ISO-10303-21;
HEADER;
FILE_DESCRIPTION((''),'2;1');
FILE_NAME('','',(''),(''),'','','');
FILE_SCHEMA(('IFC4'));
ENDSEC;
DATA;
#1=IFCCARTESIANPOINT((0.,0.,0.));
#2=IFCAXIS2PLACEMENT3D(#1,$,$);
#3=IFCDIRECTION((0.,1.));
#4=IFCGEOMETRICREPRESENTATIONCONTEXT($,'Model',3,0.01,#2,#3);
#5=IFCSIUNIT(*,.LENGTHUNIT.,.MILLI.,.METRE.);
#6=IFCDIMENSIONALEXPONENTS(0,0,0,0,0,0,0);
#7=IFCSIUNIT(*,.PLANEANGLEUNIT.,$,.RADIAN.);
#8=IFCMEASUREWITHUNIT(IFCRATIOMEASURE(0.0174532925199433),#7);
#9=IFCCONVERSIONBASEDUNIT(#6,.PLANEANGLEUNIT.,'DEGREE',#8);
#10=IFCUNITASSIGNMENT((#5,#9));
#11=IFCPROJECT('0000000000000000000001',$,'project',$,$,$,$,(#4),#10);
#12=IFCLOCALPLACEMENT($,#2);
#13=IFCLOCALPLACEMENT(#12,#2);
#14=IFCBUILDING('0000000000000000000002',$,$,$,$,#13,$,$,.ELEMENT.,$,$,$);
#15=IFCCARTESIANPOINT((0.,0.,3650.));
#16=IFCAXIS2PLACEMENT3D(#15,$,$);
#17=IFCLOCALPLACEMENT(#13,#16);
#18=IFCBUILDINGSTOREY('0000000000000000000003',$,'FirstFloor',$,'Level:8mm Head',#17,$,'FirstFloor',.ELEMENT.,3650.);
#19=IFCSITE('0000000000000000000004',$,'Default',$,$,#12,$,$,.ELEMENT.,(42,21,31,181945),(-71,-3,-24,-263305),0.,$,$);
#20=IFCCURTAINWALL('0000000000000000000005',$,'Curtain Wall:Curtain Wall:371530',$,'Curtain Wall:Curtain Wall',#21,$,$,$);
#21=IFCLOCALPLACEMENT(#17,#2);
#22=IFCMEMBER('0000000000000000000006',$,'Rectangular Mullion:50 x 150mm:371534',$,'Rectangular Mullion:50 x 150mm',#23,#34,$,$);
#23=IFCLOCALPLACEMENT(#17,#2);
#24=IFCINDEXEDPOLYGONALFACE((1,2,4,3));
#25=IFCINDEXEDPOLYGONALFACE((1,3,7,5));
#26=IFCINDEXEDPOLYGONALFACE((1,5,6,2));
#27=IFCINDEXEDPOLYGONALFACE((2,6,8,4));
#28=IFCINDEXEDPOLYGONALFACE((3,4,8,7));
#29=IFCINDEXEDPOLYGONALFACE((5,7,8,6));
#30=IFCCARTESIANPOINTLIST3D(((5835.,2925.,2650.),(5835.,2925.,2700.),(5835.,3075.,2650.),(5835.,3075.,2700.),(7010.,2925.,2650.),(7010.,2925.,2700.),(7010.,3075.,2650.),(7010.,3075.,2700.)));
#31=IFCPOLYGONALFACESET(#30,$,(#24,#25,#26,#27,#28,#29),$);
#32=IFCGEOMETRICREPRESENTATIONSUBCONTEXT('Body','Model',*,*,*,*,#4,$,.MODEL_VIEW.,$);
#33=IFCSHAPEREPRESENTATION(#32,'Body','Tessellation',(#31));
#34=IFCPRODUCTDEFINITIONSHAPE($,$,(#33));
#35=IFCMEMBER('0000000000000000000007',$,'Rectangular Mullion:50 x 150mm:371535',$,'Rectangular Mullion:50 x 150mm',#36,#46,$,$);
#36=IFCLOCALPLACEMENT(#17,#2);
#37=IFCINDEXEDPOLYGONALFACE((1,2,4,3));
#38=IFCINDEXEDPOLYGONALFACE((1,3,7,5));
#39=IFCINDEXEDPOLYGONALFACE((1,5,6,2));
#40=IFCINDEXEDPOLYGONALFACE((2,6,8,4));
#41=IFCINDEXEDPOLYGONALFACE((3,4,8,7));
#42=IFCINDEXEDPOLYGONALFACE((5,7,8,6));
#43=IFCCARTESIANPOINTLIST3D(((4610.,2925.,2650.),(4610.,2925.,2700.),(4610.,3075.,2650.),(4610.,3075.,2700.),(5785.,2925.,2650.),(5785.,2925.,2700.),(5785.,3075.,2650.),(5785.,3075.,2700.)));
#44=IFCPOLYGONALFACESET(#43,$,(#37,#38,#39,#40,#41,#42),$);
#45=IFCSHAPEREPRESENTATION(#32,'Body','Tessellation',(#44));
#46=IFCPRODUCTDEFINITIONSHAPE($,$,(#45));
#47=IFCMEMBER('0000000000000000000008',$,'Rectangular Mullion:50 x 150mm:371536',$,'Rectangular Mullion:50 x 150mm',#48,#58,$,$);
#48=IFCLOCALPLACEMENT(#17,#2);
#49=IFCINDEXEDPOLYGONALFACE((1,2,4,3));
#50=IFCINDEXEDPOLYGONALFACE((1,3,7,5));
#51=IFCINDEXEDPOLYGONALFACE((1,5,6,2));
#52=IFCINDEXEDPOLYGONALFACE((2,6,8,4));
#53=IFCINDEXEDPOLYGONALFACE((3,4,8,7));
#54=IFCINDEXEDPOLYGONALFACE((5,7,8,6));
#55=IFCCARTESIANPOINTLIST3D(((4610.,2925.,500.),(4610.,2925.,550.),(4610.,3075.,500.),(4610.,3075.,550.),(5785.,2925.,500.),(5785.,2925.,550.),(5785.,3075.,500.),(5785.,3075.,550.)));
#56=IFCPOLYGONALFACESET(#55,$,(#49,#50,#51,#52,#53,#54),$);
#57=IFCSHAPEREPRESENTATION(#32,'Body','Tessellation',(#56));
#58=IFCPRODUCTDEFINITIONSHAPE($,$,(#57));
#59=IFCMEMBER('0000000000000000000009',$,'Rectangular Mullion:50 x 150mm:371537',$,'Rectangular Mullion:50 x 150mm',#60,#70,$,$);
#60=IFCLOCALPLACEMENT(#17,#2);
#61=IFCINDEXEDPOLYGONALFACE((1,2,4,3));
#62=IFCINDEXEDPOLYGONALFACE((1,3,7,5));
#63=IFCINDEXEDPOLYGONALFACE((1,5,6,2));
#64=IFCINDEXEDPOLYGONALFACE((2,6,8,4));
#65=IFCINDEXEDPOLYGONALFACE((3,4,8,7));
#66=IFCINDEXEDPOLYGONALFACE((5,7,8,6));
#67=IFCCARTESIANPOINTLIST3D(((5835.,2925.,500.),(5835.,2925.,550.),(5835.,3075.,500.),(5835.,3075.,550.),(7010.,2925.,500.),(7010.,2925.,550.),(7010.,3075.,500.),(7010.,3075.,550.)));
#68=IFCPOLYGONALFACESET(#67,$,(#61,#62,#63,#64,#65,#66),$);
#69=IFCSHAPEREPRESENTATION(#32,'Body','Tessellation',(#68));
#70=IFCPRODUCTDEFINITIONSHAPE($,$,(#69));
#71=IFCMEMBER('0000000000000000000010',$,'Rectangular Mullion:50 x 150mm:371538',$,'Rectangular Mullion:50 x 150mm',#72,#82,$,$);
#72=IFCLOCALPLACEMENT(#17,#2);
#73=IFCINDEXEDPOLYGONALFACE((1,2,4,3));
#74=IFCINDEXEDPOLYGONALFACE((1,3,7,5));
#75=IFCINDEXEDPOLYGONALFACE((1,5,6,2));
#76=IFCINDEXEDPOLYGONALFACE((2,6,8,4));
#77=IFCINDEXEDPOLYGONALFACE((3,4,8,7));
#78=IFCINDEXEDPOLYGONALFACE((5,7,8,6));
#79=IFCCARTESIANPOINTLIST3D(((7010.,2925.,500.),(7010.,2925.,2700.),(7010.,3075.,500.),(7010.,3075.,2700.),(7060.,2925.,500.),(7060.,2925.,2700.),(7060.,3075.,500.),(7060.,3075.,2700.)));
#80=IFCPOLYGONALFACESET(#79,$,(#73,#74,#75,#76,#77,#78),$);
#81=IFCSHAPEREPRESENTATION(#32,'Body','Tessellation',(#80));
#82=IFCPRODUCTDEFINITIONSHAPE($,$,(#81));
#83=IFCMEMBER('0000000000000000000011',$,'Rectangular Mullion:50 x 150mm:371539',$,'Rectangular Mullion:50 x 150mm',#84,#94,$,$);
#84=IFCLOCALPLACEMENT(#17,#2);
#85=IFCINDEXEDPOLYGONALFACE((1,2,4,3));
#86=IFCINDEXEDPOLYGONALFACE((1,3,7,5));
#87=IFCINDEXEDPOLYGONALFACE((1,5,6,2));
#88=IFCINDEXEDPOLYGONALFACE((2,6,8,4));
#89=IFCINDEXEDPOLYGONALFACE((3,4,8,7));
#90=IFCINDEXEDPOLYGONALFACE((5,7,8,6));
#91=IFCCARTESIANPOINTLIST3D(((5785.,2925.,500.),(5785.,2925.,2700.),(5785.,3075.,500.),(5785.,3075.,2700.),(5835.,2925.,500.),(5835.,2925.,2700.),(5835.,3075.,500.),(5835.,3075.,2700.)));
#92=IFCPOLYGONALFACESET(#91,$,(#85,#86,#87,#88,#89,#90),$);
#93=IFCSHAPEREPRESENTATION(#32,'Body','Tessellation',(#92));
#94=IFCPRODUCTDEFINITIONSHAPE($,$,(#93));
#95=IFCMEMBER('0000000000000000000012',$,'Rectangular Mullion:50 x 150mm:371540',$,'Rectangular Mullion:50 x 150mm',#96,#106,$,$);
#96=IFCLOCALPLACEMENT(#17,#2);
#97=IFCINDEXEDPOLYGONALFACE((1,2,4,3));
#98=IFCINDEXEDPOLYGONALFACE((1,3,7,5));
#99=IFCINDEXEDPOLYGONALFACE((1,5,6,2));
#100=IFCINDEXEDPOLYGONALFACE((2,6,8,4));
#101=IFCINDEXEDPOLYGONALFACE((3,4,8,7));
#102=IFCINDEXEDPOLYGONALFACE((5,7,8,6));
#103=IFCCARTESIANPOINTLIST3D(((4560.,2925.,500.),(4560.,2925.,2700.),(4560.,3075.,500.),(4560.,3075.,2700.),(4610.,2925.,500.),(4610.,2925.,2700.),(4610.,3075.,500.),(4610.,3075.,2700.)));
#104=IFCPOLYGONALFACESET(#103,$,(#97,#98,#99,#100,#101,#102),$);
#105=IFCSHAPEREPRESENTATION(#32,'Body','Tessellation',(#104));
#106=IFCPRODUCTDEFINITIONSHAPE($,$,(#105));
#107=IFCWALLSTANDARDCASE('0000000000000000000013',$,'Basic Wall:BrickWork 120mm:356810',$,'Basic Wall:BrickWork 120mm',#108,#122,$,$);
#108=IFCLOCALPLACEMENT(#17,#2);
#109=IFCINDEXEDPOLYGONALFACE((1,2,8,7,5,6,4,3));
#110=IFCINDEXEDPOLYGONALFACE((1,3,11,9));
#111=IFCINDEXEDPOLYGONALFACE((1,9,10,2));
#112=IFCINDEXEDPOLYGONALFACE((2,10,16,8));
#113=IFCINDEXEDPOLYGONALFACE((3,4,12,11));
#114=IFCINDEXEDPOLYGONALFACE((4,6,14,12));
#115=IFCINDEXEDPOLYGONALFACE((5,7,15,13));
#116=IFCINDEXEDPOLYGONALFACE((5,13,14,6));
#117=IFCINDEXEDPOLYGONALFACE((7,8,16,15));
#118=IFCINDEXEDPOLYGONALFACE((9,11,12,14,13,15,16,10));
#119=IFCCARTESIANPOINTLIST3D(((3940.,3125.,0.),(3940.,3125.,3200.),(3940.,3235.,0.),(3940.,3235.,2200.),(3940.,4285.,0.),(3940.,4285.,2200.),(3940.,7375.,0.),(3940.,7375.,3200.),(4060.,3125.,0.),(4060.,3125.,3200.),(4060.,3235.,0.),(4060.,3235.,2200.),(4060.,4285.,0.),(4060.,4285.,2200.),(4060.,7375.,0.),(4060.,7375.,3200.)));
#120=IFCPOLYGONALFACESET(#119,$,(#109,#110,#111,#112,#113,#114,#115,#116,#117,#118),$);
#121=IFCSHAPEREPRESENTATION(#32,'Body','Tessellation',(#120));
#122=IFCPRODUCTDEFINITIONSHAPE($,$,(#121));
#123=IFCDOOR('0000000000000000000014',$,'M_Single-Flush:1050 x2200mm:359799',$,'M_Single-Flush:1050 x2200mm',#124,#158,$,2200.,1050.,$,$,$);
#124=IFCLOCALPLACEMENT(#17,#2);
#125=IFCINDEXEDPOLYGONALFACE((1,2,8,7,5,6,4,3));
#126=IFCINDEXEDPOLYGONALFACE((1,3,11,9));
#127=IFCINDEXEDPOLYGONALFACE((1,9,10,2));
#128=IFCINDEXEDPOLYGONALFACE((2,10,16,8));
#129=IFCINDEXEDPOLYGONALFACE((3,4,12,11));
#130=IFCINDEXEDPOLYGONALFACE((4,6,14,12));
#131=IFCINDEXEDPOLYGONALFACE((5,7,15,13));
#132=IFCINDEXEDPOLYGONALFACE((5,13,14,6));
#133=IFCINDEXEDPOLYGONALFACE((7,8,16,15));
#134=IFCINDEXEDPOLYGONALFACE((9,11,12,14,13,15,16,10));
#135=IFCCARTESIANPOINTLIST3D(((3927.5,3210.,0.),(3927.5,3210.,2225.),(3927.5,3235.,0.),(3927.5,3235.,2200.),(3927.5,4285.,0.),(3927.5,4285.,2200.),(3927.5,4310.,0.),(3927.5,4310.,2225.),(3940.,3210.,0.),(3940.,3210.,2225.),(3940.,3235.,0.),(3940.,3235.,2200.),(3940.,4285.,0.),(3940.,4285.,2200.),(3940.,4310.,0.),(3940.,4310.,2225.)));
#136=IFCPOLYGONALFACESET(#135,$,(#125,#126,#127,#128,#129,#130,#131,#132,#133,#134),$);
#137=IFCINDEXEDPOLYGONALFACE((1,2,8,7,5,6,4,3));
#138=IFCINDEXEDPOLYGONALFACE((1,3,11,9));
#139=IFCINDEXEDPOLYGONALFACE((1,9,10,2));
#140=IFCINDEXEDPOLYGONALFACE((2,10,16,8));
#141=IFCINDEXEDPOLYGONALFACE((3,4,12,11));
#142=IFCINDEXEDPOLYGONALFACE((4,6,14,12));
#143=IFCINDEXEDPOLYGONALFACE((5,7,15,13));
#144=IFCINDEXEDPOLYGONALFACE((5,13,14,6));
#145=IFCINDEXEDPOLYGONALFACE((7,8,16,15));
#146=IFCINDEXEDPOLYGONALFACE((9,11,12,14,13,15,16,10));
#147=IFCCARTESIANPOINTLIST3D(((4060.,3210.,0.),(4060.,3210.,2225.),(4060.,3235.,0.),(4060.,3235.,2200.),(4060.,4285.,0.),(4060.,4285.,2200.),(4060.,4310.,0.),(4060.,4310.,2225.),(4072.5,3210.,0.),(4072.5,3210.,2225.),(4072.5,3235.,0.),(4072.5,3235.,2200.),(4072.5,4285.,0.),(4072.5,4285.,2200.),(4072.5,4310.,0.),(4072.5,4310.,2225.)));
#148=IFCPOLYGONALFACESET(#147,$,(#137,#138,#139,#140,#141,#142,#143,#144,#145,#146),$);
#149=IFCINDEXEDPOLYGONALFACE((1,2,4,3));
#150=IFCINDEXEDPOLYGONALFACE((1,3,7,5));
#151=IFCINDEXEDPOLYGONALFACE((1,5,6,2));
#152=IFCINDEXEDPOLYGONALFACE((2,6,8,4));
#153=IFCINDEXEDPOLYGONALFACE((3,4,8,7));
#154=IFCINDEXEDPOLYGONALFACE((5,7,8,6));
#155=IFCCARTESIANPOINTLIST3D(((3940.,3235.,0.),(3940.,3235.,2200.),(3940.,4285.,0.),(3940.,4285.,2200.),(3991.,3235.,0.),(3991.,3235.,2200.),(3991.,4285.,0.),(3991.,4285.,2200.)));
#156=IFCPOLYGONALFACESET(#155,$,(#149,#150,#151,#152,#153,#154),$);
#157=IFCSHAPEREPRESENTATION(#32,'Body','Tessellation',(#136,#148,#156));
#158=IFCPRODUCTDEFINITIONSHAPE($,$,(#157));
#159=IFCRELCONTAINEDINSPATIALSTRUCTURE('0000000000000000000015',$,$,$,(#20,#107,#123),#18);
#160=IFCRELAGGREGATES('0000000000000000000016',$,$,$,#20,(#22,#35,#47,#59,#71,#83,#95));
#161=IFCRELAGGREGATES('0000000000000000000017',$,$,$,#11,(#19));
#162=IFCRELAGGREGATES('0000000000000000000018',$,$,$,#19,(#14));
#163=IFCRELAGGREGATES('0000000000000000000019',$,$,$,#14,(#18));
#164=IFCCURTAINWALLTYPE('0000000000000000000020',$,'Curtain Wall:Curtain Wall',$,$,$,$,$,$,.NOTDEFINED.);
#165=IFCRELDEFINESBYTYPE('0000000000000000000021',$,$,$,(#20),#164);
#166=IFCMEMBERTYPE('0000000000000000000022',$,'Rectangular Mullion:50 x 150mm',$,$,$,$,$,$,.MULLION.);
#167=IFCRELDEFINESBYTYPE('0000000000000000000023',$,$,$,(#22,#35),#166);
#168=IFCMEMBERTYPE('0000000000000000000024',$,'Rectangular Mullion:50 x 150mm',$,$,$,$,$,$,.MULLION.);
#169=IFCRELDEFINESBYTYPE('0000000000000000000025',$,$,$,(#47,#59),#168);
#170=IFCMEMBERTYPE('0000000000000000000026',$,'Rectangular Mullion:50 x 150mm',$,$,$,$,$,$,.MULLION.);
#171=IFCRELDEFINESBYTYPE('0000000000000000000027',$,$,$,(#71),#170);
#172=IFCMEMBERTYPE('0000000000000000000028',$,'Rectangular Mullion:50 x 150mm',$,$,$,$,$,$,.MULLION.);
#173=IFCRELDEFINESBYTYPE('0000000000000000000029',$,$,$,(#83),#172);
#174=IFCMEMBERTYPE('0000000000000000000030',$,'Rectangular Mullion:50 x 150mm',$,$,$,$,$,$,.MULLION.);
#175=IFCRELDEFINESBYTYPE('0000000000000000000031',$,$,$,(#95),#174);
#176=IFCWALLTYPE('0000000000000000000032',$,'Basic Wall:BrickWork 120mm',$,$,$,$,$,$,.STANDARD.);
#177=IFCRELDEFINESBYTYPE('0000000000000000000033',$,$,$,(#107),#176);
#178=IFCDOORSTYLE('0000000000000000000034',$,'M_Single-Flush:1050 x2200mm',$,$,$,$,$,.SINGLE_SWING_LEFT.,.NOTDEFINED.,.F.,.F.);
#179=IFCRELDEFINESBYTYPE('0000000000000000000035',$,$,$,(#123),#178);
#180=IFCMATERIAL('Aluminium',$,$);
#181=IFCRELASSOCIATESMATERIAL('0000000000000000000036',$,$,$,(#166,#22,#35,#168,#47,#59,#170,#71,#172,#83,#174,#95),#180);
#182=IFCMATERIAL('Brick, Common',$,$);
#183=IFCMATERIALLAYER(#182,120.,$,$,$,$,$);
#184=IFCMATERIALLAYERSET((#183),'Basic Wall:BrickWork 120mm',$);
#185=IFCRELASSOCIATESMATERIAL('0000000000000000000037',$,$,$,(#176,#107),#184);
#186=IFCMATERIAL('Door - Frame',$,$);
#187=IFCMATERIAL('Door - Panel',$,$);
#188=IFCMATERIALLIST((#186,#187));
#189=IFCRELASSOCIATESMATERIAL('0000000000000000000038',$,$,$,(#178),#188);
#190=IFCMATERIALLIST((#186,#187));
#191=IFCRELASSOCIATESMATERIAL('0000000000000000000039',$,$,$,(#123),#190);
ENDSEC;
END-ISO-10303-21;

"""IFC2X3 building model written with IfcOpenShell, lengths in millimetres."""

from ifc_helpers import new_model, entity, si_unit, converted_unit, direction, frame, frame_2d, origin, origin_2d_with_axis, place, context, subcontext, project, spatial, polyline, rectangle, outline, extrude, source, transform, mapped, material, material_list, layer, layer_set, layer_usage, type_object, type_shapes, element, fill, aggregate, save


model = new_model("IFC2X3")

# Units and contexts
model_context = context("Model", 3, precision=0.01, world=origin(), true_north=direction((0.0, 1.0)))
body_context = subcontext(model_context, "Body", "Model", "MODEL_VIEW")
ifc_project = project(units=[si_unit("LENGTHUNIT", "METRE", prefix="MILLI"), converted_unit("PLANEANGLEUNIT", "DEGREE", entity("IfcRatioMeasure", 0.0174532925199433), si_unit("PLANEANGLEUNIT", "RADIAN"), dimensions=[0, 0, 0, 0, 0, 0, 0])], contexts=[model_context])

# Site, building, storey
site_placement = place(None, origin())
site = spatial("IfcSite", under=ifc_project, at=site_placement, Name="Default", CompositionType="ELEMENT", RefLatitude=(42, 21, 31, 181945), RefLongitude=(-71, -3, -24, -263305), RefElevation=0.0)
building_placement = place(site_placement, origin())
building = spatial("IfcBuilding", under=site, at=building_placement, CompositionType="ELEMENT")
storey_placement = place(building_placement, frame((0.0, 0.0, 3650.0)))
storey = spatial("IfcBuildingStorey", under=building, at=storey_placement, Name="FirstFloor", ObjectType="Level:8mm Head", LongName="FirstFloor", CompositionType="ELEMENT", Elevation=3650.0)

# Curtain wall, members
curtain_wall_type = type_object("IfcCurtainWallType", Name="Curtain Wall:Curtain Wall", PredefinedType="NOTDEFINED")
curtain_wall_placement = place(storey_placement, frame((0.0, 0.0, -3650.0)))
curtain_wall = element("IfcCurtainWall", 1, at=curtain_wall_placement, inside=storey, type_object=curtain_wall_type, Name="Curtain Wall:Curtain Wall:371530", ObjectType="Curtain Wall:Curtain Wall")
ifc_material_1 = material(Name="Aluminium")
member_type_1 = type_object("IfcMemberType", Name="Rectangular Mullion:50 x 150mm", PredefinedType="MULLION", material=ifc_material_1)
shared_shape_1 = source(origin(), body_context, "Body", "SweptSolid", [
    extrude(rectangle(XDim=150.0, YDim=50.0, at=origin_2d_with_axis()), frame((-25.0, 0.0, -1175.0), z_axis=(0.0, 0.0, 1.0), x_axis=(0.0, -1.0, 0.0)), (0.0, 0.0, 1.0), 1175.0),
])
type_shapes(member_type_1, [shared_shape_1])
member_1_placement = place(storey_placement, frame((7010.0, 3000.0, 2700.0), z_axis=(1.0, 0.0, 0.0), x_axis=(0.0, 0.0, 1.0)))
member_1 = element("IfcMember", 2, at=member_1_placement, type_object=member_type_1, material=ifc_material_1, Name="Rectangular Mullion:50 x 150mm:371534", ObjectType="Rectangular Mullion:50 x 150mm", context=body_context, shape_type="MappedRepresentation", body=[
    mapped(shared_shape_1, transform((0.0, 0.0, 0.0), scale=1.0)),
])
member_2_placement = place(storey_placement, frame((5785.0, 3000.0, 2700.0), z_axis=(1.0, 0.0, 0.0), x_axis=(0.0, 0.0, 1.0)))
member_2 = element("IfcMember", 3, at=member_2_placement, type_object=member_type_1, material=ifc_material_1, Name="Rectangular Mullion:50 x 150mm:371535", ObjectType="Rectangular Mullion:50 x 150mm", context=body_context, shape_type="MappedRepresentation", body=[
    mapped(shared_shape_1, transform((0.0, 0.0, 0.0), scale=1.0)),
])
member_type_2 = type_object("IfcMemberType", Name="Rectangular Mullion:50 x 150mm", PredefinedType="MULLION", material=ifc_material_1)
shared_shape_2 = source(origin(), body_context, "Body", "SweptSolid", [
    extrude(rectangle(XDim=150.0, YDim=50.0, at=origin_2d_with_axis()), frame((-25.0, 0.0, -1175.0), z_axis=(0.0, 0.0, 1.0), x_axis=(0.0, -1.0, 0.0)), (0.0, 0.0, 1.0), 1175.0),
])
type_shapes(member_type_2, [shared_shape_2])
member_3_placement = place(storey_placement, frame((4610.0, 3000.0, 500.0), z_axis=(-1.0, 0.0, 0.0), x_axis=(0.0, 0.0, -1.0)))
member_3 = element("IfcMember", 4, at=member_3_placement, type_object=member_type_2, material=ifc_material_1, Name="Rectangular Mullion:50 x 150mm:371536", ObjectType="Rectangular Mullion:50 x 150mm", context=body_context, shape_type="MappedRepresentation", body=[
    mapped(shared_shape_2, transform((0.0, 0.0, 0.0), scale=1.0)),
])
member_4_placement = place(storey_placement, frame((5835.0, 3000.0, 500.0), z_axis=(-1.0, 0.0, 0.0), x_axis=(0.0, 0.0, -1.0)))
member_4 = element("IfcMember", 5, at=member_4_placement, type_object=member_type_2, material=ifc_material_1, Name="Rectangular Mullion:50 x 150mm:371537", ObjectType="Rectangular Mullion:50 x 150mm", context=body_context, shape_type="MappedRepresentation", body=[
    mapped(shared_shape_2, transform((0.0, 0.0, 0.0), scale=1.0)),
])
member_type_3 = type_object("IfcMemberType", Name="Rectangular Mullion:50 x 150mm", PredefinedType="MULLION", material=ifc_material_1)
shared_shape_3 = source(origin(), body_context, "Body", "SweptSolid", [
    extrude(rectangle(XDim=150.0, YDim=50.0, at=origin_2d_with_axis()), frame((-25.0, 0.0, -2200.0), z_axis=(0.0, 0.0, 1.0), x_axis=(0.0, -1.0, 0.0)), (0.0, 0.0, 1.0), 2200.0),
])
type_shapes(member_type_3, [shared_shape_3])
member_5_placement = place(storey_placement, frame((7060.0, 3000.0, 500.0), z_axis=(0.0, 0.0, -1.0), x_axis=(1.0, 0.0, 0.0)))
member_5 = element("IfcMember", 6, at=member_5_placement, type_object=member_type_3, material=ifc_material_1, Name="Rectangular Mullion:50 x 150mm:371538", ObjectType="Rectangular Mullion:50 x 150mm", context=body_context, shape_type="MappedRepresentation", body=[
    mapped(shared_shape_3, transform((0.0, 0.0, 0.0), scale=1.0)),
])
member_type_4 = type_object("IfcMemberType", Name="Rectangular Mullion:50 x 150mm", PredefinedType="MULLION", material=ifc_material_1)
shared_shape_4 = source(origin(), body_context, "Body", "SweptSolid", [
    extrude(rectangle(XDim=150.0, YDim=50.0, at=origin_2d_with_axis()), frame((0.0, 0.0, -2200.0), z_axis=(0.0, 0.0, 1.0), x_axis=(0.0, -1.0, 0.0)), (0.0, 0.0, 1.0), 2200.0),
])
type_shapes(member_type_4, [shared_shape_4])
member_6_placement = place(storey_placement, frame((5810.0, 3000.0, 500.0), z_axis=(0.0, 0.0, -1.0), x_axis=(1.0, 0.0, 0.0)))
member_6 = element("IfcMember", 7, at=member_6_placement, type_object=member_type_4, material=ifc_material_1, Name="Rectangular Mullion:50 x 150mm:371539", ObjectType="Rectangular Mullion:50 x 150mm", context=body_context, shape_type="MappedRepresentation", body=[
    mapped(shared_shape_4, transform((0.0, 0.0, 0.0), scale=1.0)),
])
member_type_5 = type_object("IfcMemberType", Name="Rectangular Mullion:50 x 150mm", PredefinedType="MULLION", material=ifc_material_1)
shared_shape_5 = source(origin(), body_context, "Body", "SweptSolid", [
    extrude(rectangle(XDim=150.0, YDim=50.0, at=origin_2d_with_axis()), frame((-25.0, 0.0, -2200.0), z_axis=(0.0, 0.0, 1.0), x_axis=(0.0, -1.0, 0.0)), (0.0, 0.0, 1.0), 2200.0),
])
type_shapes(member_type_5, [shared_shape_5])
member_7_placement = place(storey_placement, frame((4560.0, 3000.0, 2700.0), z_axis=(0.0, 0.0, 1.0), x_axis=(-1.0, 0.0, 0.0)))
member_7 = element("IfcMember", 8, at=member_7_placement, type_object=member_type_5, material=ifc_material_1, Name="Rectangular Mullion:50 x 150mm:371540", ObjectType="Rectangular Mullion:50 x 150mm", context=body_context, shape_type="MappedRepresentation", body=[
    mapped(shared_shape_5, transform((0.0, 0.0, 0.0), scale=1.0)),
])

aggregate(curtain_wall, [member_1, member_2, member_3, member_4, member_5, member_6, member_7])

# Wall, opening, door
ifc_material_2 = material(Name="Brick, Common")
ifc_layer_1 = layer(ifc_material_2, 120.0)
ifc_layer_set_1 = layer_set([ifc_layer_1], Name="Basic Wall:BrickWork 120mm")
ifc_layer_usage_1 = layer_usage(ifc_layer_set_1, "AXIS2", "NEGATIVE", 60.0)
wall_type = type_object("IfcWallType", Name="Basic Wall:BrickWork 120mm", PredefinedType="STANDARD", material=ifc_layer_set_1)
wall_placement = place(storey_placement, frame((4000.0, 7375.0, 0.0), z_axis=(0.0, 0.0, 1.0), x_axis=(0.0, -1.0, 0.0)))
wall = element("IfcWallStandardCase", 9, at=wall_placement, inside=storey, type_object=wall_type, material=ifc_layer_usage_1, Name="Basic Wall:BrickWork 120mm:356810", ObjectType="Basic Wall:BrickWork 120mm", context=body_context, shape_type="SweptSolid", body=[
    extrude(rectangle(XDim=4250.0, YDim=120.0, at=frame_2d((2125.0, 0.0), x_axis=(-1.0, 0.0))), origin(), (0.0, 0.0, 1.0), 3200.0),
])
opening_placement = place(wall_placement, frame((4140.0, 60.0, 0.0)))
opening = element("IfcOpeningElement", 10, at=opening_placement, cuts=wall, ObjectType="Opening", context=body_context, shape_type="SweptSolid", body=[
    extrude(rectangle(XDim=1050.0, YDim=2200.0, at=frame_2d((1100.0, 525.0), x_axis=(0.0, -1.0))), frame((0.0, 0.0, 0.0), z_axis=(0.0, -1.0, 0.0), x_axis=(0.0, 0.0, 1.0)), (0.0, 0.0, 1.0), 120.0),
])
ifc_material_3 = material(Name="Door - Frame")
ifc_material_4 = material(Name="Door - Panel")
ifc_material_list_1 = material_list([ifc_material_3, ifc_material_4])
ifc_material_list_2 = material_list([ifc_material_3, ifc_material_4])
door_style = type_object("IfcDoorStyle", Name="M_Single-Flush:1050 x2200mm", ConstructionType="NOTDEFINED", OperationType="SINGLE_SWING_LEFT", ParameterTakesPrecedence=False, Sizeable=False, material=ifc_material_list_2)
shared_shape_6 = source(origin(), body_context, "Body", "SweptSolid", [
    extrude(outline(polyline([(-550.0, -1118.8), (550.0, -1118.8), (550.0, 1106.2), (525.0, 1106.2), (525.0, -1093.8), (-525.0, -1093.8), (-525.0, 1106.2), (-550.0, 1106.2), (-550.0, -1118.8)])), frame((525.0, 132.5, 1106.2), z_axis=(0.0, -1.0, 0.0), x_axis=(-1.0, 0.0, 0.0)), (0.0, 0.0, 1.0), 12.5),
    extrude(outline(polyline([(-1118.8, -550.0), (1106.2, -550.0), (1106.2, -525.0), (-1093.8, -525.0), (-1093.8, 525.0), (1106.2, 525.0), (1106.2, 550.0), (-1118.8, 550.0), (-1118.8, -550.0)])), frame((525.0, 0.0, 1106.2), z_axis=(0.0, -1.0, 0.0), x_axis=(0.0, 0.0, -1.0)), (0.0, 0.0, 1.0), 12.5),
    extrude(rectangle(XDim=1050.0, YDim=51.0, at=frame_2d((0.0, 0.0), x_axis=(1.0, 0.0))), frame((525.0, 94.5, 0.0)), (0.0, 0.0, 1.0), 2200.0),
])
type_shapes(door_style, [shared_shape_6])
door_placement = place(opening_placement, frame((0.0, 0.0, 0.0), z_axis=(0.0, 0.0, 1.0), x_axis=(-1.0, 0.0, 0.0)))
door = element("IfcDoor", 11, at=door_placement, inside=storey, type_object=door_style, material=ifc_material_list_1, Name="M_Single-Flush:1050 x2200mm:359799", ObjectType="M_Single-Flush:1050 x2200mm", OverallHeight=2200.0, OverallWidth=1050.0, context=body_context, shape_type="MappedRepresentation", body=[
    mapped(shared_shape_6, transform((0.0, 0.0, 0.0), scale=1.0)),
])
fill(opening, door)

save(model, "model.ifc")
